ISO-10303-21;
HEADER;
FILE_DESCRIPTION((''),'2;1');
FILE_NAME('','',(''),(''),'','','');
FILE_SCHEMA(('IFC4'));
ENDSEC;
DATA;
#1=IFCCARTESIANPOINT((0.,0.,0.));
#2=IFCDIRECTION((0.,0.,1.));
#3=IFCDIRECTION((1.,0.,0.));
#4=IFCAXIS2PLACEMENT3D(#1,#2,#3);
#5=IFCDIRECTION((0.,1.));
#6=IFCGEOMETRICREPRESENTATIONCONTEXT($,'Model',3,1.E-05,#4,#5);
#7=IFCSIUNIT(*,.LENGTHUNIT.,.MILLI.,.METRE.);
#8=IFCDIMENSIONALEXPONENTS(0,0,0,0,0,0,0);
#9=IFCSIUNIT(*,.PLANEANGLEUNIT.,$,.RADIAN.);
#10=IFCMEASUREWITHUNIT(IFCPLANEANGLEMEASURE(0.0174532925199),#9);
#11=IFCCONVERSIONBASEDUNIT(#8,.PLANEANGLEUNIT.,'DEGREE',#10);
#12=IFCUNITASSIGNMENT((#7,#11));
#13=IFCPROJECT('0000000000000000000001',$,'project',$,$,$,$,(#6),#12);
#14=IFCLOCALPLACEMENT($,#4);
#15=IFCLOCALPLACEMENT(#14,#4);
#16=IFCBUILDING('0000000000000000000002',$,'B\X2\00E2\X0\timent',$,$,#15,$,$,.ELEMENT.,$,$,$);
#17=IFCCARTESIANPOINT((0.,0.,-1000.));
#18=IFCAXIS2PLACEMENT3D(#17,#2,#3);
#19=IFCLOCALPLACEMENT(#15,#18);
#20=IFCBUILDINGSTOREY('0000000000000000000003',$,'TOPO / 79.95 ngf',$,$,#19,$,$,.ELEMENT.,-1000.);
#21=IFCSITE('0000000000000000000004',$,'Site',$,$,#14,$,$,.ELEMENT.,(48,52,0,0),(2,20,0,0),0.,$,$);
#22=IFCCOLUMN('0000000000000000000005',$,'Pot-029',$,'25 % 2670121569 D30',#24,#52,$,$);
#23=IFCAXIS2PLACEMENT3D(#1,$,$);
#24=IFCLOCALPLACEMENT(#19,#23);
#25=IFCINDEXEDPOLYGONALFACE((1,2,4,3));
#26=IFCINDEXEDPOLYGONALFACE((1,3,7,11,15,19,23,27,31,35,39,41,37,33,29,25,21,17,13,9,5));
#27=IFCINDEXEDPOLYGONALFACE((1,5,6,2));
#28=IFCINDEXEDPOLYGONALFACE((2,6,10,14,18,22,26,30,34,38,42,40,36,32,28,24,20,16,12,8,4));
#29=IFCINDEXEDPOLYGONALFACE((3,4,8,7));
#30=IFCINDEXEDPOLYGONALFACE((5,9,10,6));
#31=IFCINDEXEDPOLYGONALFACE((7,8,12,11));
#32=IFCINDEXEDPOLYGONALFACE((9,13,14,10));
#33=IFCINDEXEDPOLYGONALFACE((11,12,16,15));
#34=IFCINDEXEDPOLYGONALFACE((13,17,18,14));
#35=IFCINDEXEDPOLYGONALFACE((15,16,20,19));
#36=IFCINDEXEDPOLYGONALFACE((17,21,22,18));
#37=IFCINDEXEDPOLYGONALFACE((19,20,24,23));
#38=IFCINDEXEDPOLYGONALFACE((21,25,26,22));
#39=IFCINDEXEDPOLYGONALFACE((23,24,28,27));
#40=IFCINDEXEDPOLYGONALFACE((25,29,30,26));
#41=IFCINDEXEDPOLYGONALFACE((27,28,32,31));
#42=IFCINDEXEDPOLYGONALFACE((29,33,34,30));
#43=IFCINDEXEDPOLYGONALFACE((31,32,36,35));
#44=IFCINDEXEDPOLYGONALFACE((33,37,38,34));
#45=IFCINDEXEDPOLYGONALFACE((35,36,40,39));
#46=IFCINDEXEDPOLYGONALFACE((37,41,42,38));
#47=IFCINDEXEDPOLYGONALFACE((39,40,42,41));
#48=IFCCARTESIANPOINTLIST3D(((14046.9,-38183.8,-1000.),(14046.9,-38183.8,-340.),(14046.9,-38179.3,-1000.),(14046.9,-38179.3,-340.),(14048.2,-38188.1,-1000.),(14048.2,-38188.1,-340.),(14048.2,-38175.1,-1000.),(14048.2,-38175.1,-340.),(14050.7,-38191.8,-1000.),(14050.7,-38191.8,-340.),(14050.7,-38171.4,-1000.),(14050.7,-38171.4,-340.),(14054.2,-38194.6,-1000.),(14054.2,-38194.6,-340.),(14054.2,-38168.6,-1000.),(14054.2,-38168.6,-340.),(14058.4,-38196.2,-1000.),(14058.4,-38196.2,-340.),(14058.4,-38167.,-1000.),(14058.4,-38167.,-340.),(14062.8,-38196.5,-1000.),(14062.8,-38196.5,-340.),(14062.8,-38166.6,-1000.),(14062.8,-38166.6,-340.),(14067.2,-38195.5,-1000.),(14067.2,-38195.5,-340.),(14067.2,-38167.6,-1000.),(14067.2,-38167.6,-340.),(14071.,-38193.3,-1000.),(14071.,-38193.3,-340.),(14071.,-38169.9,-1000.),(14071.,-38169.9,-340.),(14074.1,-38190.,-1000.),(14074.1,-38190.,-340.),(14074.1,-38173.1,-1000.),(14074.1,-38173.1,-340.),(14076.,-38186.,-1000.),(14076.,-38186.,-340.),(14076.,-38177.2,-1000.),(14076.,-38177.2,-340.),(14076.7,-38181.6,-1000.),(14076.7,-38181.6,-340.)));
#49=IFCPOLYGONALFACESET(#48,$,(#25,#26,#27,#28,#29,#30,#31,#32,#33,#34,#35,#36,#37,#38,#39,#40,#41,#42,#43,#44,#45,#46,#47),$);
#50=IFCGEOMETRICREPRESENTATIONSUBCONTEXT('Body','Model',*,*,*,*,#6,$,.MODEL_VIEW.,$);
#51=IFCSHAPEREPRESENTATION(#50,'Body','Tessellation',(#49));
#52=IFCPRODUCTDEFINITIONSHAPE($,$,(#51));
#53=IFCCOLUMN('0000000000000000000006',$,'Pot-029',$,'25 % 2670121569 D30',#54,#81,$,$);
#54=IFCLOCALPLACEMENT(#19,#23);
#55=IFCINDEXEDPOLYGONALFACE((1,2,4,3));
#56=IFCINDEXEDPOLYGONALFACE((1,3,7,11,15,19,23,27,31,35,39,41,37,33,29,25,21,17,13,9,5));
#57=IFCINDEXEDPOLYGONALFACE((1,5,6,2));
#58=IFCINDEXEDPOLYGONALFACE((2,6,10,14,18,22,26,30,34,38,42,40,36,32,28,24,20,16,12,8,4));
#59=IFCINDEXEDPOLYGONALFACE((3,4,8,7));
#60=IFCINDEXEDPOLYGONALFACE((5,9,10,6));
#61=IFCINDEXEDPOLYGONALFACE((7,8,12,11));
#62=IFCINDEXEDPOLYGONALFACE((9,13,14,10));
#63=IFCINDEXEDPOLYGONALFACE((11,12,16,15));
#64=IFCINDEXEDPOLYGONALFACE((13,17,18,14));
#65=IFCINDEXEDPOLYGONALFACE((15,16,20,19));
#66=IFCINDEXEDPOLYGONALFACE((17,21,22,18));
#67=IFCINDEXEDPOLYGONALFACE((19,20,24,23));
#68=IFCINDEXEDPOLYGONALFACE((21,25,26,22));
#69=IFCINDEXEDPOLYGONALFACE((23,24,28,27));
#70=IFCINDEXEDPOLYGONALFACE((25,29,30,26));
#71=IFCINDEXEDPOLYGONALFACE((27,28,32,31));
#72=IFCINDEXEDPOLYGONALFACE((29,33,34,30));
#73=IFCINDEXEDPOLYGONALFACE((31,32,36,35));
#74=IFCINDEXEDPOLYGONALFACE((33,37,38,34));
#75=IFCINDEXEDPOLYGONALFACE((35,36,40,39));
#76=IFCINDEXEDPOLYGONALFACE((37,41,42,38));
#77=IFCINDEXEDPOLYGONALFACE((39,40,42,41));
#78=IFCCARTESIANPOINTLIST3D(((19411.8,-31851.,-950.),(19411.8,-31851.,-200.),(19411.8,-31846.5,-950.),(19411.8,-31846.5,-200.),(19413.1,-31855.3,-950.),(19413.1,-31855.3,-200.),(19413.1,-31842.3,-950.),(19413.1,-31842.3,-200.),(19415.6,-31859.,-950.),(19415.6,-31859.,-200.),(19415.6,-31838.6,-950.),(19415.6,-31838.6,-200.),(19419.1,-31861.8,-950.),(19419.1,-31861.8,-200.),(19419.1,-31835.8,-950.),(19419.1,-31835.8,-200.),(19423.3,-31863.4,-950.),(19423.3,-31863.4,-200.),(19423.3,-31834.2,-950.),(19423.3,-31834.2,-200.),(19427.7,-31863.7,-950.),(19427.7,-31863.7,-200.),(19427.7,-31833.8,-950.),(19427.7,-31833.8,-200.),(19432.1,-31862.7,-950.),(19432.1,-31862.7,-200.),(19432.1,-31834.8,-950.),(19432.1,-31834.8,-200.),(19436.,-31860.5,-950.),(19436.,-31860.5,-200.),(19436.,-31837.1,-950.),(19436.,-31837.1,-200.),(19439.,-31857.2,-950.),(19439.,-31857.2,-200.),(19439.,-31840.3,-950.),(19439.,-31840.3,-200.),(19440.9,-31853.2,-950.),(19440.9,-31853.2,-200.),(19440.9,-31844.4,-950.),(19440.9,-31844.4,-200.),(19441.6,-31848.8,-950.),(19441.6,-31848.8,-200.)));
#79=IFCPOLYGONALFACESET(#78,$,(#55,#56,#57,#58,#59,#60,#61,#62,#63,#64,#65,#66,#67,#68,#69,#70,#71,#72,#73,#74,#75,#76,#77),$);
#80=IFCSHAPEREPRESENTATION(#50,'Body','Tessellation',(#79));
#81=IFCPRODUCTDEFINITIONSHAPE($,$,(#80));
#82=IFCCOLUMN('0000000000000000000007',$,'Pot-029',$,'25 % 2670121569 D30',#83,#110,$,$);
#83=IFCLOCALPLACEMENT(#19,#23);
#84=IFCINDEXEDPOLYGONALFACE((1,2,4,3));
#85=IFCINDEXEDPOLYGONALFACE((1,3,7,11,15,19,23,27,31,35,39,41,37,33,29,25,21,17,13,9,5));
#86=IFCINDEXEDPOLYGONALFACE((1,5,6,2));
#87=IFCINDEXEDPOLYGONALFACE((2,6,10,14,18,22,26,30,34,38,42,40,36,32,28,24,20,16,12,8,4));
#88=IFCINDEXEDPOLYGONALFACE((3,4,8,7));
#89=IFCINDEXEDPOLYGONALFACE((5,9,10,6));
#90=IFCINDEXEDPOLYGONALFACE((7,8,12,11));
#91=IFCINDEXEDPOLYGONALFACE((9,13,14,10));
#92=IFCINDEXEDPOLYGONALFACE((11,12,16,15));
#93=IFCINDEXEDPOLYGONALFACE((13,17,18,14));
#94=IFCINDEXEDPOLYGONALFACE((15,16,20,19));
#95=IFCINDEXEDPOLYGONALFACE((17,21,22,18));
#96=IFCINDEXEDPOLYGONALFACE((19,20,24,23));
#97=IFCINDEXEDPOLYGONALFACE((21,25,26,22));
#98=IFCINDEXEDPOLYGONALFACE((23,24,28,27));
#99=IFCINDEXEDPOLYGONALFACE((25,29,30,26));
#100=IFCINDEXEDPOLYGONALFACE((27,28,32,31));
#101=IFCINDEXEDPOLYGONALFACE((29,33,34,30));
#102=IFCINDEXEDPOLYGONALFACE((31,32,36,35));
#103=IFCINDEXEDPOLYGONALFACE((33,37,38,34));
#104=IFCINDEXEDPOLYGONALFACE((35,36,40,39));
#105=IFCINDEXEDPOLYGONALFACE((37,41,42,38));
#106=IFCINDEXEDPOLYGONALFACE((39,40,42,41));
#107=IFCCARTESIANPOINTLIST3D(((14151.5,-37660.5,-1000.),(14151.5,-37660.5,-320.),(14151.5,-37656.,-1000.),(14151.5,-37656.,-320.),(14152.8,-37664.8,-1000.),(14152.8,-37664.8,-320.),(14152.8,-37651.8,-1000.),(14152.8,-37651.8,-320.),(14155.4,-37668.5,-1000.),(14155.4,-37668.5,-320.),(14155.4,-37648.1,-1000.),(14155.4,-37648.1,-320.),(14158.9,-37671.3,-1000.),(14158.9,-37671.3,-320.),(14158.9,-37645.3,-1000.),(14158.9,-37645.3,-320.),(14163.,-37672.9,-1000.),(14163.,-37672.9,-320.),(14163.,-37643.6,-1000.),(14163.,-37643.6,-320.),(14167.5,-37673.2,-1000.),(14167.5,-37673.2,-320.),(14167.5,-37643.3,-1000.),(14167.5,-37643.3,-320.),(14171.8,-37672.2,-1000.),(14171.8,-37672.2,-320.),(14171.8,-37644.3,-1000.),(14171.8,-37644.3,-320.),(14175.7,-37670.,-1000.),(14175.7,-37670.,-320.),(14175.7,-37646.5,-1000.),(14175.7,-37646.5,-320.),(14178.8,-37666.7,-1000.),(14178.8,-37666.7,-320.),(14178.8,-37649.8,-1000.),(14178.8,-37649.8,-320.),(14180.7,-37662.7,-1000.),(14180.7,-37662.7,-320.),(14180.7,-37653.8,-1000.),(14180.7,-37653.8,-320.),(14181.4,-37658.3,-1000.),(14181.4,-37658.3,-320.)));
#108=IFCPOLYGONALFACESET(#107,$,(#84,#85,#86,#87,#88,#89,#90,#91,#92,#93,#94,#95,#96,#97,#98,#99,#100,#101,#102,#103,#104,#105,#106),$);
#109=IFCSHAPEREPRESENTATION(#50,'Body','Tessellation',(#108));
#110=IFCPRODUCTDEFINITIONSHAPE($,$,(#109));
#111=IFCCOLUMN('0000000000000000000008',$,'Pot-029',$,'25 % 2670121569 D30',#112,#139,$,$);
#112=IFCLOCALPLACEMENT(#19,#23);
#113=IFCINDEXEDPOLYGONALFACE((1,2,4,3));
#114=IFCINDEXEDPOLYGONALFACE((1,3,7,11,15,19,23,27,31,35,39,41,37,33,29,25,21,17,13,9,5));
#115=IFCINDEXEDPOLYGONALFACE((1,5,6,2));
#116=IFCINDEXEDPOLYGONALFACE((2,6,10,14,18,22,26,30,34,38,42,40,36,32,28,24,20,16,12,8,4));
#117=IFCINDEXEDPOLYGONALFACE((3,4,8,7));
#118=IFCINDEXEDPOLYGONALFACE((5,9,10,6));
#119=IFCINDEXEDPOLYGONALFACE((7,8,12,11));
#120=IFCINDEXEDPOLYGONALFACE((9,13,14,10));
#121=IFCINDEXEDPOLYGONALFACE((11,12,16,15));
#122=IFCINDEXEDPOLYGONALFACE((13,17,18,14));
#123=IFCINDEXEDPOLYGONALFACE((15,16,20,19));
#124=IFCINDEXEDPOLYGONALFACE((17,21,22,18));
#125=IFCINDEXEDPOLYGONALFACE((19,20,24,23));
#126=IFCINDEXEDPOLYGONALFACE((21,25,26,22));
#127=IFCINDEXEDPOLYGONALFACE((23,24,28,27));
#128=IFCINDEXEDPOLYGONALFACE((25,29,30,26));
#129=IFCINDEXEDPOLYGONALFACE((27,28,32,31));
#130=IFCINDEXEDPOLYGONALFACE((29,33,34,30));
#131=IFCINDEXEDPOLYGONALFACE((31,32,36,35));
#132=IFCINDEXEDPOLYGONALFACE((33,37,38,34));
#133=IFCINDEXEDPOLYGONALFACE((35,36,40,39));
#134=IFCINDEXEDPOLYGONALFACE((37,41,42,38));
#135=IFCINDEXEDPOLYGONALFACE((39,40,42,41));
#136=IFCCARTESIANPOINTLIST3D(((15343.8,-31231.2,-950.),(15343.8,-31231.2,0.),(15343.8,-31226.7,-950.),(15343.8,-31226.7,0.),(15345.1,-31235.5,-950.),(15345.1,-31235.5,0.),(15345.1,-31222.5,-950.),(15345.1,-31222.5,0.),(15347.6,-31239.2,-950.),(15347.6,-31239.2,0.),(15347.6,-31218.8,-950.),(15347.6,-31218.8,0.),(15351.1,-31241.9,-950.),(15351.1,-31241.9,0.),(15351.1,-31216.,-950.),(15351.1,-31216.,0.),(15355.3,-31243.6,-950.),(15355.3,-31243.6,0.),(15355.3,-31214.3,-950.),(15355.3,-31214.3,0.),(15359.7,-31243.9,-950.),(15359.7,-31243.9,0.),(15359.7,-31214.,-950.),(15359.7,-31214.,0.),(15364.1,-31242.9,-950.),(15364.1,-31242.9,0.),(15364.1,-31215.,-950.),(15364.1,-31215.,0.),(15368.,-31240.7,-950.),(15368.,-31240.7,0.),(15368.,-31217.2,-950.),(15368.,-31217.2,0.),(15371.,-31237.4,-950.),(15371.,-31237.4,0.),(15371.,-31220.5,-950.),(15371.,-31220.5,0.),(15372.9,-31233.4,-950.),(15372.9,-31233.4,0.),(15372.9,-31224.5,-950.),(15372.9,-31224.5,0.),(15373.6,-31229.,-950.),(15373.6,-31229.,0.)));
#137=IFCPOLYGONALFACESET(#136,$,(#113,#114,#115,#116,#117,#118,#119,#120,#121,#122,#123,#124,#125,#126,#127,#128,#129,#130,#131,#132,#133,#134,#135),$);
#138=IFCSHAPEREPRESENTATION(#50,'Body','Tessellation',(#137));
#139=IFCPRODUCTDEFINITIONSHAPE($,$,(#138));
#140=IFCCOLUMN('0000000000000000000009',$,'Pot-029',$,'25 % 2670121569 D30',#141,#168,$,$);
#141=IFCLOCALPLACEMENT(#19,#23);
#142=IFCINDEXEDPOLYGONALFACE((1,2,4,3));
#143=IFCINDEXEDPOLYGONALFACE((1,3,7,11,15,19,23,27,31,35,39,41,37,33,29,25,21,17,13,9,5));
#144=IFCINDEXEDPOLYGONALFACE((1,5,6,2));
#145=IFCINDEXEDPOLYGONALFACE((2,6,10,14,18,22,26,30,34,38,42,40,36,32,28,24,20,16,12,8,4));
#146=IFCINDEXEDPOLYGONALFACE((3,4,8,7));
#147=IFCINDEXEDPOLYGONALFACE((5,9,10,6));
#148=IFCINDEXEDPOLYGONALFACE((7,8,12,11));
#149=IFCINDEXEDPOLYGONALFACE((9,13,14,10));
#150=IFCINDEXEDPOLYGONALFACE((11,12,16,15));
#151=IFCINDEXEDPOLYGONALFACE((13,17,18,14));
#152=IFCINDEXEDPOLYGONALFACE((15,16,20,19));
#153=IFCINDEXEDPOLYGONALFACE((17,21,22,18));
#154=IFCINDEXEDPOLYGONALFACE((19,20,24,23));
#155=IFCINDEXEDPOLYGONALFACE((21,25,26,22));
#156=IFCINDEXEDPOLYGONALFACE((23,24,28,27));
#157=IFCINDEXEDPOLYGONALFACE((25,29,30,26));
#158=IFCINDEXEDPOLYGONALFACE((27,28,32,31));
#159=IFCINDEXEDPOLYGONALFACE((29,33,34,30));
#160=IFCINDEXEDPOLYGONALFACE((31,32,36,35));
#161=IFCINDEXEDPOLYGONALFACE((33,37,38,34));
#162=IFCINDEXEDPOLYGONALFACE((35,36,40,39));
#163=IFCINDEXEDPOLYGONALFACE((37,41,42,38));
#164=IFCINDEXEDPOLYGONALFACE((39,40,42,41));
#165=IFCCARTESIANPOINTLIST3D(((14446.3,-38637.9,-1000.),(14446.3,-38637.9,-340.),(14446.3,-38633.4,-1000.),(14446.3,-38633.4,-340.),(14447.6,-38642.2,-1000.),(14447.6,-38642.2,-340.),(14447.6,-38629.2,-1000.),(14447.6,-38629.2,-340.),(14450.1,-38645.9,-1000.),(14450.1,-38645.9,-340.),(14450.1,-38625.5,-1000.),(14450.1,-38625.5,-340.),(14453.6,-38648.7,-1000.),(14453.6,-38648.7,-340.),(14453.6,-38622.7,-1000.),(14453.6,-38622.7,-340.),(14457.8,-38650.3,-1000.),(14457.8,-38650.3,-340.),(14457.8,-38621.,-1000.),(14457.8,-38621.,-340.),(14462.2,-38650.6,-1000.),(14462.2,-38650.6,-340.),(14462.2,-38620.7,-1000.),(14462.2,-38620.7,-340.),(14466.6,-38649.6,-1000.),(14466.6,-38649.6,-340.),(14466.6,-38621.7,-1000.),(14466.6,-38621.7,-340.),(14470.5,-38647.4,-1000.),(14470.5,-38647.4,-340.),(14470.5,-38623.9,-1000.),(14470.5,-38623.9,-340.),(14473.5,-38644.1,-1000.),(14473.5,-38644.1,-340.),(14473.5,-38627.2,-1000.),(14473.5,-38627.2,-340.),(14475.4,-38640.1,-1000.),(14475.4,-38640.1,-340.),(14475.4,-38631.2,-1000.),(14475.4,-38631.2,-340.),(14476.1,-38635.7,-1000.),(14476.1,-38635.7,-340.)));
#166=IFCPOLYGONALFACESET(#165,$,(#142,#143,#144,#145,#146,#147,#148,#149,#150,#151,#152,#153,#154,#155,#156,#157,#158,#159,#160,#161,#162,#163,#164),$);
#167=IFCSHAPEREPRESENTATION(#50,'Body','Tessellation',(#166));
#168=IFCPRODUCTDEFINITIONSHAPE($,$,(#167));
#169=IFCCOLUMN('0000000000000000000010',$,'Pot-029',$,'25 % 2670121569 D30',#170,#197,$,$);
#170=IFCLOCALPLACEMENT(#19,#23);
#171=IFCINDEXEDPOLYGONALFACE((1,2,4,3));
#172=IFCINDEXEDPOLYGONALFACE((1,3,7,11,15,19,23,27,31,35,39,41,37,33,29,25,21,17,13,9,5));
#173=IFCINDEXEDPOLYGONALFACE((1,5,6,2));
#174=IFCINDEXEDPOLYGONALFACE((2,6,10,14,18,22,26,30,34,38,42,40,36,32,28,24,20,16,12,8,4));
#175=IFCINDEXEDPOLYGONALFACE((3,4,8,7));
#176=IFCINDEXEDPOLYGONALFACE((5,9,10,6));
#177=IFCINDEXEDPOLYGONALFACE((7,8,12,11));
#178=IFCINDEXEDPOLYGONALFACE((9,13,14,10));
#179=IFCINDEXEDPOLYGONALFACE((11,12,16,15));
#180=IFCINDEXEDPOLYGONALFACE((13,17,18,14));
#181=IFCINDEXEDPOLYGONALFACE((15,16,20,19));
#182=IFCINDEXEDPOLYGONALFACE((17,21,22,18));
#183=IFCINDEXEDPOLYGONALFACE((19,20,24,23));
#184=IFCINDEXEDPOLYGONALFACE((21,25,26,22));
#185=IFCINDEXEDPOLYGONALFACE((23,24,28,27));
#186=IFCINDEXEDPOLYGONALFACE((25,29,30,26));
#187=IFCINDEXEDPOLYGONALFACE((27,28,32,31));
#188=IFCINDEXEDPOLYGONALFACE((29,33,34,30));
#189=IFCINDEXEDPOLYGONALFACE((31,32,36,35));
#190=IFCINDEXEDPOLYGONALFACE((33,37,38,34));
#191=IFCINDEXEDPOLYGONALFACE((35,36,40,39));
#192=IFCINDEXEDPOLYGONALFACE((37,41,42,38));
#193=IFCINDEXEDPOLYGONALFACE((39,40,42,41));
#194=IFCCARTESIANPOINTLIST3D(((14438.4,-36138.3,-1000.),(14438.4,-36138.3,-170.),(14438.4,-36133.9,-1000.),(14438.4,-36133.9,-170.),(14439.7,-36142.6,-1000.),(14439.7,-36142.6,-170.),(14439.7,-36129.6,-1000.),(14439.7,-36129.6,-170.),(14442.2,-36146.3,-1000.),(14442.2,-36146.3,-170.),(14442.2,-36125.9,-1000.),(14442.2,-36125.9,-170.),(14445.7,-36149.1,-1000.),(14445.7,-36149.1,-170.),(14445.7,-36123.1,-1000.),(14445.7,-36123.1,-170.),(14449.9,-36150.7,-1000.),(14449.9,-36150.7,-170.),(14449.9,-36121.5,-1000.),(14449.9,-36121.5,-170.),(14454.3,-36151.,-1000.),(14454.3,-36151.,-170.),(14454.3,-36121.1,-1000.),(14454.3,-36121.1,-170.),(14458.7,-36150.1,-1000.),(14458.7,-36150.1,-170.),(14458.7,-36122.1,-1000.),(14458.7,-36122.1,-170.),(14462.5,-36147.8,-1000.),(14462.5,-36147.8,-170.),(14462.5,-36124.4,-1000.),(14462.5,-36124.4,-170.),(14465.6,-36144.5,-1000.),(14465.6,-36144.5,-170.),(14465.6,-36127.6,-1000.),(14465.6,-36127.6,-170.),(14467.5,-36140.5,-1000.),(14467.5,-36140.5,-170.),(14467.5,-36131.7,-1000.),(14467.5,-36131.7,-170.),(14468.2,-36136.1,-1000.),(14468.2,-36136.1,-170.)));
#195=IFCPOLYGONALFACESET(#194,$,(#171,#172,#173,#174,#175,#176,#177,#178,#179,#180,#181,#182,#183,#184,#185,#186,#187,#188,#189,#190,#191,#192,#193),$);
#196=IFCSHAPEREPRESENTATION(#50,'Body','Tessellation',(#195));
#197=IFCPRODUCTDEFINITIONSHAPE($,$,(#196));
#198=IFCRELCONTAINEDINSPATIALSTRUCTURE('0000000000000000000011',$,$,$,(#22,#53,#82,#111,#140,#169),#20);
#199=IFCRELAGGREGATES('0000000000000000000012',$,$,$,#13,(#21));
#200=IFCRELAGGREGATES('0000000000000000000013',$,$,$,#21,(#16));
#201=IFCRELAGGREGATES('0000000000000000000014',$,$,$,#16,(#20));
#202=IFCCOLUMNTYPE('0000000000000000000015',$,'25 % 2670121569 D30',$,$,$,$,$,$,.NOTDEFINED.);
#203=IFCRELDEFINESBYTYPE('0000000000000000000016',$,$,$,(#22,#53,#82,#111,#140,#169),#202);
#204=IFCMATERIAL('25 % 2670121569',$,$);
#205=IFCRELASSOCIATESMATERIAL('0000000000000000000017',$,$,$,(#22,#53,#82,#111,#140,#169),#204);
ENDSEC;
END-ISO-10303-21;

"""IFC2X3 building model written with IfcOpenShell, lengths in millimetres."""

from ifc_helpers import new_model, entity, si_unit, converted_unit, direction, frame, origin_with_axes, origin_2d_with_axis, place, context, subcontext, project, spatial, circle, extrude, material, type_object, element, save


model = new_model("IFC2X3")

# Units and contexts
model_context = context("Model", 3, precision=1e-05, world=origin_with_axes(), true_north=direction((0.0, 1.0)))
body_context = subcontext(model_context, "Body", "Model", "MODEL_VIEW")
ifc_project = project(units=[si_unit("LENGTHUNIT", "METRE", prefix="MILLI"), converted_unit("PLANEANGLEUNIT", "DEGREE", entity("IfcPlaneAngleMeasure", 0.0174532925199), si_unit("PLANEANGLEUNIT", "RADIAN"), dimensions=[0, 0, 0, 0, 0, 0, 0])], contexts=[model_context])

# Site, building, storey
site_placement = place(None, origin_with_axes())
site = spatial("IfcSite", under=ifc_project, at=site_placement, Name="Site", CompositionType="ELEMENT", RefLatitude=(48, 52, 0, 0), RefLongitude=(2, 20, 0, 0), RefElevation=0.0)
building_placement = place(site_placement, origin_with_axes())
building = spatial("IfcBuilding", under=site, at=building_placement, Name="Bâtiment", CompositionType="ELEMENT")
storey_placement = place(building_placement, frame((0.0, 0.0, -1000.0), z_axis=(0.0, 0.0, 1.0), x_axis=(1.0, 0.0, 0.0)))
storey = spatial("IfcBuildingStorey", under=building, at=storey_placement, Name="TOPO / 79.95 ngf", CompositionType="ELEMENT", Elevation=-1000.0)

# Columns
ifc_material_1 = material(Name="25 % 2670121569")
column_type = type_object("IfcColumnType", Name="25 % 2670121569 D30", PredefinedType="NOTDEFINED")
column_1_placement = place(storey_placement, frame((14061.7, -38181.6, -1000.0), z_axis=(0.0, 0.0, 1.0), x_axis=(1.0, 0.0, 0.0)))
element("IfcColumn", 1, at=column_1_placement, inside=storey, type_object=column_type, material=ifc_material_1, Name="Pot-029", ObjectType="25 % 2670121569 D30", context=body_context, shape_type="SweptSolid", body=[
    extrude(circle(Radius=15.0, at=origin_2d_with_axis()), origin_with_axes(), (0.0, 0.0, 1.0), 660.0),
])
column_2_placement = place(storey_placement, frame((19426.6, -31848.8, -950.0), z_axis=(0.0, 0.0, 1.0), x_axis=(1.0, 0.0, 0.0)))
element("IfcColumn", 2, at=column_2_placement, inside=storey, type_object=column_type, material=ifc_material_1, Name="Pot-029", ObjectType="25 % 2670121569 D30", context=body_context, shape_type="SweptSolid", body=[
    extrude(circle(Radius=15.0, at=origin_2d_with_axis()), origin_with_axes(), (0.0, 0.0, 1.0), 750.0),
])
column_3_placement = place(storey_placement, frame((14166.4, -37658.3, -1000.0), z_axis=(0.0, 0.0, 1.0), x_axis=(1.0, 0.0, 0.0)))
element("IfcColumn", 3, at=column_3_placement, inside=storey, type_object=column_type, material=ifc_material_1, Name="Pot-029", ObjectType="25 % 2670121569 D30", context=body_context, shape_type="SweptSolid", body=[
    extrude(circle(Radius=15.0, at=origin_2d_with_axis()), origin_with_axes(), (0.0, 0.0, 1.0), 680.0),
])
column_4_placement = place(storey_placement, frame((15358.6, -31229.0, -950.0), z_axis=(0.0, 0.0, 1.0), x_axis=(1.0, 0.0, 0.0)))
element("IfcColumn", 4, at=column_4_placement, inside=storey, type_object=column_type, material=ifc_material_1, Name="Pot-029", ObjectType="25 % 2670121569 D30", context=body_context, shape_type="SweptSolid", body=[
    extrude(circle(Radius=15.0, at=origin_2d_with_axis()), origin_with_axes(), (0.0, 0.0, 1.0), 950.0),
])
column_5_placement = place(storey_placement, frame((14461.1, -38635.7, -1000.0), z_axis=(0.0, 0.0, 1.0), x_axis=(1.0, 0.0, 0.0)))
element("IfcColumn", 5, at=column_5_placement, inside=storey, type_object=column_type, material=ifc_material_1, Name="Pot-029", ObjectType="25 % 2670121569 D30", context=body_context, shape_type="SweptSolid", body=[
    extrude(circle(Radius=15.0, at=origin_2d_with_axis()), origin_with_axes(), (0.0, 0.0, 1.0), 660.0),
])
column_6_placement = place(storey_placement, frame((14453.2, -36136.1, -1000.0), z_axis=(0.0, 0.0, 1.0), x_axis=(1.0, 0.0, 0.0)))
element("IfcColumn", 6, at=column_6_placement, inside=storey, type_object=column_type, material=ifc_material_1, Name="Pot-029", ObjectType="25 % 2670121569 D30", context=body_context, shape_type="SweptSolid", body=[
    extrude(circle(Radius=15.0, at=origin_2d_with_axis()), origin_with_axes(), (0.0, 0.0, 1.0), 830.0),
])

save(model, "model.ifc")
